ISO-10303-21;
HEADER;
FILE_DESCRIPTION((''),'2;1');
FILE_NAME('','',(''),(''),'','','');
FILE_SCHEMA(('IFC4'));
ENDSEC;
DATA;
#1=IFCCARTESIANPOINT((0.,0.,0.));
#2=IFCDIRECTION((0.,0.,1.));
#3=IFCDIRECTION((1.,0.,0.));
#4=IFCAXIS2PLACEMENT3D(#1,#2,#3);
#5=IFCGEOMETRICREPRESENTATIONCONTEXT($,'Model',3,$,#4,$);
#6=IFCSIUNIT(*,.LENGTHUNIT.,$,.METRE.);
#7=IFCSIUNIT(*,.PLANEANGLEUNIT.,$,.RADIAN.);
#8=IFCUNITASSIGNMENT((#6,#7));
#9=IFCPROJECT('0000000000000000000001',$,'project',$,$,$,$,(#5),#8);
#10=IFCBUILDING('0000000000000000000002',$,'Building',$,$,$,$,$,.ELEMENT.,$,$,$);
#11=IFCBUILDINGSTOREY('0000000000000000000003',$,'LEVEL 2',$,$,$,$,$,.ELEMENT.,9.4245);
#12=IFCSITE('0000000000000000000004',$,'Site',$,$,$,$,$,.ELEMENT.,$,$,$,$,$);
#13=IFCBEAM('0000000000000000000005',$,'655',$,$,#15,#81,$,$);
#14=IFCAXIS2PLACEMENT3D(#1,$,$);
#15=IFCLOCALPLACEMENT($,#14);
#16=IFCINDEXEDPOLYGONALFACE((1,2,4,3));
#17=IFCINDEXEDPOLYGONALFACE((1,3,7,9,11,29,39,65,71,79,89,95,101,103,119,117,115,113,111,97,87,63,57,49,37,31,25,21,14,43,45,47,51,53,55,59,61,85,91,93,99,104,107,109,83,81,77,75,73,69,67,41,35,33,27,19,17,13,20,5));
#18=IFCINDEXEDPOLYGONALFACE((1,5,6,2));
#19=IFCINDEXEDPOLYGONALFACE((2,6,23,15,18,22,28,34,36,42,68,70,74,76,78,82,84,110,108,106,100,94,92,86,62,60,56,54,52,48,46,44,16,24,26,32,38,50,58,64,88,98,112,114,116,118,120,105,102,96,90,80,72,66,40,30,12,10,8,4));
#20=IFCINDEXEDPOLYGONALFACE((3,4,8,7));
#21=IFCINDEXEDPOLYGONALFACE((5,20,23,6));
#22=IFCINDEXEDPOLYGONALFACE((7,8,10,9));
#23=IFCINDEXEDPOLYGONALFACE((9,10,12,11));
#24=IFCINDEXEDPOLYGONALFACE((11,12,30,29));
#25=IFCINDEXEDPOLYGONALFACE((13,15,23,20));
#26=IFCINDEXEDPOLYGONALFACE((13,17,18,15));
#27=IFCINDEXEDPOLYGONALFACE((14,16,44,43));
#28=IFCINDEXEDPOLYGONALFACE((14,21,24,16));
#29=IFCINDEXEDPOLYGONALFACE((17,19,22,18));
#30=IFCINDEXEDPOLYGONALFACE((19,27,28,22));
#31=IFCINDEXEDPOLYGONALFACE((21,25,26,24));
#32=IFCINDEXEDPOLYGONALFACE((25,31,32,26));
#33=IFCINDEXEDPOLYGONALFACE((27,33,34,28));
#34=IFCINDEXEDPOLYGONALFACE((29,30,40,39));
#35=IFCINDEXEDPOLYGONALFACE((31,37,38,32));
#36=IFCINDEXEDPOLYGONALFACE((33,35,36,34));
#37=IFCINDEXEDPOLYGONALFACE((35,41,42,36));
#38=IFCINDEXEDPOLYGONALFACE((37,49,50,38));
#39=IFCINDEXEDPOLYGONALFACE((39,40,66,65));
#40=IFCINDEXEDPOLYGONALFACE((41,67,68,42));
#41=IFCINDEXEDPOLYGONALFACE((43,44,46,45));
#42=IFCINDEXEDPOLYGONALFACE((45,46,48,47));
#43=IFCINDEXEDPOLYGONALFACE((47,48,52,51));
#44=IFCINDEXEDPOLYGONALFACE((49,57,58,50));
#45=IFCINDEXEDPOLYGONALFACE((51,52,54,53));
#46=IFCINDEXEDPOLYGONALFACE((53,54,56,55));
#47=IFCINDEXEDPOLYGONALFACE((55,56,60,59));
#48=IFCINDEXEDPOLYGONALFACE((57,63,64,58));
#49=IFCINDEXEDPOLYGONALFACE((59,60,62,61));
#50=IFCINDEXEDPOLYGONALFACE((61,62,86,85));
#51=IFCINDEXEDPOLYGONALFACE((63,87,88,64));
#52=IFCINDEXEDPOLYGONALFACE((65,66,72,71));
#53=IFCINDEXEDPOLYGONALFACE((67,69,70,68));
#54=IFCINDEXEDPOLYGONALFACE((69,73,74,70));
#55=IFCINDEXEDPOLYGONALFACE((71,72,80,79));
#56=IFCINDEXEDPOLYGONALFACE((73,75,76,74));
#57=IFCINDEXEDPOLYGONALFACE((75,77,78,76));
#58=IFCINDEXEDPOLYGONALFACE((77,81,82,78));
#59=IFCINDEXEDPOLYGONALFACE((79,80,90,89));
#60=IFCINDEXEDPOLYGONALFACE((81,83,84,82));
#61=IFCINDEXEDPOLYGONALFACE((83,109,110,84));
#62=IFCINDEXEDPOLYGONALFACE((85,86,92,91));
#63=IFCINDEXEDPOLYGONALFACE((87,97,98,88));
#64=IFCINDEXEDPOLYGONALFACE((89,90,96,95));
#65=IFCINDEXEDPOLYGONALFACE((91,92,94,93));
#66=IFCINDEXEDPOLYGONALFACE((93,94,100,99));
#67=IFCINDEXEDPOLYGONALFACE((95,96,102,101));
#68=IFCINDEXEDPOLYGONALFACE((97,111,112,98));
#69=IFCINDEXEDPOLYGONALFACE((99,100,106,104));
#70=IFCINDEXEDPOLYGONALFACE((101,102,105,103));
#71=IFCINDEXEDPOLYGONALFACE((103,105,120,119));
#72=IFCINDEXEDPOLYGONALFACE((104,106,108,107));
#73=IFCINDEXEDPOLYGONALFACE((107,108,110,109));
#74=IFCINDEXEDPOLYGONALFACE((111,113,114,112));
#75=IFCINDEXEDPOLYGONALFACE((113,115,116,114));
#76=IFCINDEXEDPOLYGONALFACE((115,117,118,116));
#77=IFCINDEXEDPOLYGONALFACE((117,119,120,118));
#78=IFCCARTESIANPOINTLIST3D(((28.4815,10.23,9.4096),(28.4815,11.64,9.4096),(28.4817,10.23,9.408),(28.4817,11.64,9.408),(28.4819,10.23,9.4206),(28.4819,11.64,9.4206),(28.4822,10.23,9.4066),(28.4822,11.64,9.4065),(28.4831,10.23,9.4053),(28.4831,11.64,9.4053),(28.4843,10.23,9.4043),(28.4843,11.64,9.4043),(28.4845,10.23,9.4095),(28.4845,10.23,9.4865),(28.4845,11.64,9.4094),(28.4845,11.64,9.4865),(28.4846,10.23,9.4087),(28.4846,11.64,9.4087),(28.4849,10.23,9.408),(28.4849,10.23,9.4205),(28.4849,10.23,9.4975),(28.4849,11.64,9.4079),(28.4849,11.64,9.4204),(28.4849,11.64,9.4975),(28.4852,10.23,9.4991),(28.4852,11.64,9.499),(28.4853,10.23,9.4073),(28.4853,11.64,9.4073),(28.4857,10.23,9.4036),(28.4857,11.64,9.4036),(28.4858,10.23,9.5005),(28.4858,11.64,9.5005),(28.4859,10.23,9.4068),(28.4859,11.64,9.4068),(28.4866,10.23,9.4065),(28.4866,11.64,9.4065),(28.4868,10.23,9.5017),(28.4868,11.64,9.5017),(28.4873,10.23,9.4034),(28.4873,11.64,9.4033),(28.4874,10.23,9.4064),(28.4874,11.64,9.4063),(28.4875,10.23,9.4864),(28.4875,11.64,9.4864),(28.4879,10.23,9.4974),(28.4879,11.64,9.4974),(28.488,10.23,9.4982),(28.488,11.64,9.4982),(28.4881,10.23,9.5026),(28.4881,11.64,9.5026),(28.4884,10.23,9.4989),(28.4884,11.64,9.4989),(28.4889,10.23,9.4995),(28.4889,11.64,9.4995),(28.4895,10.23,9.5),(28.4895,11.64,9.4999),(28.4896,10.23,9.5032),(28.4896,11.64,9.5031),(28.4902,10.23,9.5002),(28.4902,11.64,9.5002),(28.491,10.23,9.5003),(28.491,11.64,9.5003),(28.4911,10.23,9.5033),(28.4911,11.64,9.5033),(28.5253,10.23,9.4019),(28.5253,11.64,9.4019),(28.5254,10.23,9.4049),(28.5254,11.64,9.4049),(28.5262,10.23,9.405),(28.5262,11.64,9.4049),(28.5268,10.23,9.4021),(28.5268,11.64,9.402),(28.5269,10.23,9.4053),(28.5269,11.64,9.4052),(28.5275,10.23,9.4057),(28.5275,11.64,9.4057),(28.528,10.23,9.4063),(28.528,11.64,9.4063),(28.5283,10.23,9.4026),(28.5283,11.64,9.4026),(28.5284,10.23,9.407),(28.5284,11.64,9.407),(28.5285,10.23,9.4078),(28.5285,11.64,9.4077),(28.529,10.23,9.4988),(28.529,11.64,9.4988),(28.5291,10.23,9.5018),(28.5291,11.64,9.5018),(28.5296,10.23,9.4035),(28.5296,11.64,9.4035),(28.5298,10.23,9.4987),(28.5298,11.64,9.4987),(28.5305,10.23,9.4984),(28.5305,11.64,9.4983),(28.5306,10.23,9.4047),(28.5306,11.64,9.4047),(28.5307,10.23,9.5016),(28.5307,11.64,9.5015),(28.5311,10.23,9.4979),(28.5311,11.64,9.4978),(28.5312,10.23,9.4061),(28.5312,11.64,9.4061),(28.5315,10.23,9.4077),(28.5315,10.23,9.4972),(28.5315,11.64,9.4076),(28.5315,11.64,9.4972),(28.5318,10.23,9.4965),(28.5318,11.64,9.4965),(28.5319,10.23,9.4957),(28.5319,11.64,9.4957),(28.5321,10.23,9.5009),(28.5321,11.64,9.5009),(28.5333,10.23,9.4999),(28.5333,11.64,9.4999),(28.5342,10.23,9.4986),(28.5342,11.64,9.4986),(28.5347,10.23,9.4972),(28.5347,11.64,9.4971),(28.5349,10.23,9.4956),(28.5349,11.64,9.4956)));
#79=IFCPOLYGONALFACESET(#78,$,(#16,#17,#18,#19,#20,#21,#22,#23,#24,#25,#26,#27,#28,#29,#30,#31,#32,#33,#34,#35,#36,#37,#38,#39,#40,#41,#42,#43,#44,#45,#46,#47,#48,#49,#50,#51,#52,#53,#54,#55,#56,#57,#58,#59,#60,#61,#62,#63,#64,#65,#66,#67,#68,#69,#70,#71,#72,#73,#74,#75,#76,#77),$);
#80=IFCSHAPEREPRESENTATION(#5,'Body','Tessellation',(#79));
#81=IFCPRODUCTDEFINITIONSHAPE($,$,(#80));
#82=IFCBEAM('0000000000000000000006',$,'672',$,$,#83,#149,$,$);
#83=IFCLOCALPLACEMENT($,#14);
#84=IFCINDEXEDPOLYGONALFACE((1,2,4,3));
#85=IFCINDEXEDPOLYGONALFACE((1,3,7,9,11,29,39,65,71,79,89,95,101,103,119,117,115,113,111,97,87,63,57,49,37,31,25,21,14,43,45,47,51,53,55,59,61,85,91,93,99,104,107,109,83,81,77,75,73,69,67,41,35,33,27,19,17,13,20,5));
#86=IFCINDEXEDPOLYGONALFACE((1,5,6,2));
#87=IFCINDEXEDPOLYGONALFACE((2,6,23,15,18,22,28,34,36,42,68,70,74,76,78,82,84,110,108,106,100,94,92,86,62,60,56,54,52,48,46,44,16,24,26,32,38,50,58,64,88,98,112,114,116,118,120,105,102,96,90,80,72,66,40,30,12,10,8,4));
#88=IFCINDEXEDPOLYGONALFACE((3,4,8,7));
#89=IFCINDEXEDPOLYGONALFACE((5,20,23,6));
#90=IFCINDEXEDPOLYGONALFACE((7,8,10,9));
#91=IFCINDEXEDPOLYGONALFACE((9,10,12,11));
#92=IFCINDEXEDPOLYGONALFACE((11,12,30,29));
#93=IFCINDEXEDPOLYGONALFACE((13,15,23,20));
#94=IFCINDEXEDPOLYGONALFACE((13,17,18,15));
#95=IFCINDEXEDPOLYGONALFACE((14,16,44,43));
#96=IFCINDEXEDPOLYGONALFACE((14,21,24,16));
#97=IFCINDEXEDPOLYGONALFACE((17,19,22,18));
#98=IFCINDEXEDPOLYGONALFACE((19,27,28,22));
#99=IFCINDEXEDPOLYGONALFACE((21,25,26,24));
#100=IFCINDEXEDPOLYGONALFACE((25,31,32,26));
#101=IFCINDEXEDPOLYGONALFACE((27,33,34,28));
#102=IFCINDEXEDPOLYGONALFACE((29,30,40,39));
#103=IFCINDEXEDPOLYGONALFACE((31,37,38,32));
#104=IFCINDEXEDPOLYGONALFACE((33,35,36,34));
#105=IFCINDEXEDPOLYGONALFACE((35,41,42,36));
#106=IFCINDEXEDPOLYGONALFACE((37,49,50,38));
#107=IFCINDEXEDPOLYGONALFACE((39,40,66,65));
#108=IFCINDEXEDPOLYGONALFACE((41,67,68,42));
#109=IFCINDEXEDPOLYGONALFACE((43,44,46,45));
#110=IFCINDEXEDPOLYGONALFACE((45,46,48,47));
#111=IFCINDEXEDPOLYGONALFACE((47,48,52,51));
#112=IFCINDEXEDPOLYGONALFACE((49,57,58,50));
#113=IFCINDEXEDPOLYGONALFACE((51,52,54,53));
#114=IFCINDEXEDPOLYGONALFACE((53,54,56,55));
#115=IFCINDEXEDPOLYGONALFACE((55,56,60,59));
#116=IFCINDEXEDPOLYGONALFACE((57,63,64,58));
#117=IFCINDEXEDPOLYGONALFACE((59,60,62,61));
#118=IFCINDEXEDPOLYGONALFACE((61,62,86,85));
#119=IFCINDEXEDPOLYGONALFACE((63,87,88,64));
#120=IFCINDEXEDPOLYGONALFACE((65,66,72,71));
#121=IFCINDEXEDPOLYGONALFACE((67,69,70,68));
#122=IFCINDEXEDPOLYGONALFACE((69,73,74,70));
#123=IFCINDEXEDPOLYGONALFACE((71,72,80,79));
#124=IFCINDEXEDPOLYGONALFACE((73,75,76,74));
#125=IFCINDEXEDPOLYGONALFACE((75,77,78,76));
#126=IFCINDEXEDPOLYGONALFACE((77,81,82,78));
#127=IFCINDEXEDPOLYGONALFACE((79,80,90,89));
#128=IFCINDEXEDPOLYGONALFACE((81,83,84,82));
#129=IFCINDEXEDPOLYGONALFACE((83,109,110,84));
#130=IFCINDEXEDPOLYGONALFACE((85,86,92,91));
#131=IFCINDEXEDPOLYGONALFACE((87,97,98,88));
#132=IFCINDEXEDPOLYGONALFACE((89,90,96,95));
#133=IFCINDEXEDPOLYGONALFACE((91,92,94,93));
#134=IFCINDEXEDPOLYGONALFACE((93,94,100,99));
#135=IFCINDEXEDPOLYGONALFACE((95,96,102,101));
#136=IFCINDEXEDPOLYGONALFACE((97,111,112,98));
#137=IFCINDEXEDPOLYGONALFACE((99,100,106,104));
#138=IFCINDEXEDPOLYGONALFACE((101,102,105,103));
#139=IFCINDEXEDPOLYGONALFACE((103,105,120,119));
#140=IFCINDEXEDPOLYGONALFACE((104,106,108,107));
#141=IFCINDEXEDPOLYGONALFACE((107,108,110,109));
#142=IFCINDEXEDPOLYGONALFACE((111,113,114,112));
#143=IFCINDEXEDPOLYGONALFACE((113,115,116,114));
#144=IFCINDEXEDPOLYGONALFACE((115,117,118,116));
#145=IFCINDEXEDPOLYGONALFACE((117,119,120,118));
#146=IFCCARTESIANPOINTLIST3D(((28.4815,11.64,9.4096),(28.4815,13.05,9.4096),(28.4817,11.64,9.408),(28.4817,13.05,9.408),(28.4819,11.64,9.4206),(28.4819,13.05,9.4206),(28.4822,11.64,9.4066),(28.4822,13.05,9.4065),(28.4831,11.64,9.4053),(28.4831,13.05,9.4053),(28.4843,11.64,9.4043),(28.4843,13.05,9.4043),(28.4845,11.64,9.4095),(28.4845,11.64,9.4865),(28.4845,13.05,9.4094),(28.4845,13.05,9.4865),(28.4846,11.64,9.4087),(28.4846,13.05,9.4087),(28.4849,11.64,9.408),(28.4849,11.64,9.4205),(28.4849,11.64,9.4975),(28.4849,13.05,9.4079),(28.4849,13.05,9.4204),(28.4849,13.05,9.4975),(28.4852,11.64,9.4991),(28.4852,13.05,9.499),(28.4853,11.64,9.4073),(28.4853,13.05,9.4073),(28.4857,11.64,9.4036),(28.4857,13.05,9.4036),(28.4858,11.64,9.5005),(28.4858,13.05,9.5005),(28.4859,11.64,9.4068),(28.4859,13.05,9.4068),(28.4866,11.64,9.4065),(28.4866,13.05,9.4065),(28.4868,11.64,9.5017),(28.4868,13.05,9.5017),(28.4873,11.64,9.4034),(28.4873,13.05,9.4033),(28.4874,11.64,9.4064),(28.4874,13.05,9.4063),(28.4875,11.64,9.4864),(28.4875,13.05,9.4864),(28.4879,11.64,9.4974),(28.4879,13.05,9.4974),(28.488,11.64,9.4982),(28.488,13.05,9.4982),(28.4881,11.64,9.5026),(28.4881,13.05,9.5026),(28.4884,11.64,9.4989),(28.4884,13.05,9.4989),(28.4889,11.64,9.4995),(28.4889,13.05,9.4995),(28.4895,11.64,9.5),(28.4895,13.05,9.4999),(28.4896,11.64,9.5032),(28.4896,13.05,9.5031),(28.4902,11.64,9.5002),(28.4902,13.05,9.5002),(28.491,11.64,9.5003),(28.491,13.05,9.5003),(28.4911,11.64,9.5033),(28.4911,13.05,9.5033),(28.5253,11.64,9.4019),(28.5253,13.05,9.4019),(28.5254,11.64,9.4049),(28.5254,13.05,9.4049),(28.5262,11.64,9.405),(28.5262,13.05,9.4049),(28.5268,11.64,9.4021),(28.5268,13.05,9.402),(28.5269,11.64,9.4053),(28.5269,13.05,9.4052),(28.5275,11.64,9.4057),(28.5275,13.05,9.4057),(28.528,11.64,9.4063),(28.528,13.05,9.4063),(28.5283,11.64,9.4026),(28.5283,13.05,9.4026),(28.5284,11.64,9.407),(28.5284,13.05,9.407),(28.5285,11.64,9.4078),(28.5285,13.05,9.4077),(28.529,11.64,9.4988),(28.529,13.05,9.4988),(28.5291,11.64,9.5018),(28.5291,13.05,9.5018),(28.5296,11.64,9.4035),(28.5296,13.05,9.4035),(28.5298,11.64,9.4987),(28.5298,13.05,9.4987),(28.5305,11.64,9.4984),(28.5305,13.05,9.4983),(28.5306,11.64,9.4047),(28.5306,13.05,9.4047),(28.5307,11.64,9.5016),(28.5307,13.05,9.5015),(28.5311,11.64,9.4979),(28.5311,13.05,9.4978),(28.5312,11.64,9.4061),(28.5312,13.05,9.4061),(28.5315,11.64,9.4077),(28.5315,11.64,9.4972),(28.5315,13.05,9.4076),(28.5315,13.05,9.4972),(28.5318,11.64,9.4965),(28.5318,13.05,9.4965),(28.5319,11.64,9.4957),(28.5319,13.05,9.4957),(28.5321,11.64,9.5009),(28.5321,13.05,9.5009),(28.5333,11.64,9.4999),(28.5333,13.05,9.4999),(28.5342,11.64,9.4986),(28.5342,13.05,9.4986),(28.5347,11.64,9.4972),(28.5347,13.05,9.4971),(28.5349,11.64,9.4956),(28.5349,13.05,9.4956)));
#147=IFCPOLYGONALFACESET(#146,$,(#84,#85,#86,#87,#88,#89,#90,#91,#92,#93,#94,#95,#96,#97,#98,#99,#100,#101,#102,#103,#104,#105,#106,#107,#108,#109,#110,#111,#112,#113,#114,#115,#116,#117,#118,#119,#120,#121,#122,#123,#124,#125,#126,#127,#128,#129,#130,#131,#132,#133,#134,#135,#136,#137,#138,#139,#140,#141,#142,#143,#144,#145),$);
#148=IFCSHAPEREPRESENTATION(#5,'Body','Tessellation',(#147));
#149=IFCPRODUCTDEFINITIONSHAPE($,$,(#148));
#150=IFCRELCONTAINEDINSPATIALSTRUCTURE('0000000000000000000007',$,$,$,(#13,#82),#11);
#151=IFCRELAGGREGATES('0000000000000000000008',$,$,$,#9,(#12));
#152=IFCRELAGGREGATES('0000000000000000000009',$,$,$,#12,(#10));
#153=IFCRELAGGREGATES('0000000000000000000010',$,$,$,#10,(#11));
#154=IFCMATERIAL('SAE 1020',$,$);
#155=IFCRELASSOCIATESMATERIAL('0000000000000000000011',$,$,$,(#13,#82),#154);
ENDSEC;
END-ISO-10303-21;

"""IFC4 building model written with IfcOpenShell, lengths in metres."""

from ifc_helpers import new_model, si_unit, frame, origin_with_axes, origin_2d_with_axis, place, context, project, spatial, c_section, extrude, material, material_profile, profile_set, profile_usage, element, save


model = new_model("IFC4")

# Units and contexts
model_context = context("Model", 3, world=origin_with_axes())
ifc_project = project(units=[si_unit("LENGTHUNIT", "METRE"), si_unit("PLANEANGLEUNIT", "RADIAN")], contexts=[model_context])

# Site, building, storey
site = spatial("IfcSite", under=ifc_project, Name="Site", CompositionType="ELEMENT")
building = spatial("IfcBuilding", under=site, Name="Building", CompositionType="ELEMENT")
storey = spatial("IfcBuildingStorey", under=building, Name="LEVEL 2", CompositionType="ELEMENT", Elevation=9.4245)

# Beams
ifc_material = material(Name="SAE 1020")
ifc_material_profile_1 = material_profile(ifc_material, c_section(Depth=0.1, Width=0.05, WallThickness=0.003, Girth=0.017, InternalFilletRadius=0.003, at=origin_2d_with_axis()))
ifc_profile_set_1 = profile_set([ifc_material_profile_1])
ifc_profile_usage_1 = profile_usage(ifc_profile_set_1, cardinal=10)
beam_1_placement = place(None, frame((28.5082, 10.23, 9.4526), z_axis=(0.0, 1.0, -0.00003), x_axis=(-0.999256, 0.000001, 0.038562)))
element("IfcBeam", 1, at=beam_1_placement, inside=storey, material=ifc_profile_usage_1, Name="655", context=model_context, shape_type="SweptSolid", body=[
    extrude(c_section(Depth=0.1, Width=0.05, WallThickness=0.003, Girth=0.017, InternalFilletRadius=0.003, at=origin_2d_with_axis()), origin_with_axes(), (0.0, 0.0, 1.0), 1.41),
])
ifc_material_profile_2 = material_profile(ifc_material, c_section(Depth=0.1, Width=0.05, WallThickness=0.003, Girth=0.017, InternalFilletRadius=0.003, at=origin_2d_with_axis()))
ifc_profile_set_2 = profile_set([ifc_material_profile_2])
ifc_profile_usage_2 = profile_usage(ifc_profile_set_2, cardinal=10)
beam_2_placement = place(None, frame((28.5082, 11.64, 9.4526), z_axis=(0.0, 1.0, -0.00003), x_axis=(-0.999256, 0.000001, 0.038562)))
element("IfcBeam", 2, at=beam_2_placement, inside=storey, material=ifc_profile_usage_2, Name="672", context=model_context, shape_type="SweptSolid", body=[
    extrude(c_section(Depth=0.1, Width=0.05, WallThickness=0.003, Girth=0.017, InternalFilletRadius=0.003, at=origin_2d_with_axis()), origin_with_axes(), (0.0, 0.0, 1.0), 1.41),
])

save(model, "model.ifc")
